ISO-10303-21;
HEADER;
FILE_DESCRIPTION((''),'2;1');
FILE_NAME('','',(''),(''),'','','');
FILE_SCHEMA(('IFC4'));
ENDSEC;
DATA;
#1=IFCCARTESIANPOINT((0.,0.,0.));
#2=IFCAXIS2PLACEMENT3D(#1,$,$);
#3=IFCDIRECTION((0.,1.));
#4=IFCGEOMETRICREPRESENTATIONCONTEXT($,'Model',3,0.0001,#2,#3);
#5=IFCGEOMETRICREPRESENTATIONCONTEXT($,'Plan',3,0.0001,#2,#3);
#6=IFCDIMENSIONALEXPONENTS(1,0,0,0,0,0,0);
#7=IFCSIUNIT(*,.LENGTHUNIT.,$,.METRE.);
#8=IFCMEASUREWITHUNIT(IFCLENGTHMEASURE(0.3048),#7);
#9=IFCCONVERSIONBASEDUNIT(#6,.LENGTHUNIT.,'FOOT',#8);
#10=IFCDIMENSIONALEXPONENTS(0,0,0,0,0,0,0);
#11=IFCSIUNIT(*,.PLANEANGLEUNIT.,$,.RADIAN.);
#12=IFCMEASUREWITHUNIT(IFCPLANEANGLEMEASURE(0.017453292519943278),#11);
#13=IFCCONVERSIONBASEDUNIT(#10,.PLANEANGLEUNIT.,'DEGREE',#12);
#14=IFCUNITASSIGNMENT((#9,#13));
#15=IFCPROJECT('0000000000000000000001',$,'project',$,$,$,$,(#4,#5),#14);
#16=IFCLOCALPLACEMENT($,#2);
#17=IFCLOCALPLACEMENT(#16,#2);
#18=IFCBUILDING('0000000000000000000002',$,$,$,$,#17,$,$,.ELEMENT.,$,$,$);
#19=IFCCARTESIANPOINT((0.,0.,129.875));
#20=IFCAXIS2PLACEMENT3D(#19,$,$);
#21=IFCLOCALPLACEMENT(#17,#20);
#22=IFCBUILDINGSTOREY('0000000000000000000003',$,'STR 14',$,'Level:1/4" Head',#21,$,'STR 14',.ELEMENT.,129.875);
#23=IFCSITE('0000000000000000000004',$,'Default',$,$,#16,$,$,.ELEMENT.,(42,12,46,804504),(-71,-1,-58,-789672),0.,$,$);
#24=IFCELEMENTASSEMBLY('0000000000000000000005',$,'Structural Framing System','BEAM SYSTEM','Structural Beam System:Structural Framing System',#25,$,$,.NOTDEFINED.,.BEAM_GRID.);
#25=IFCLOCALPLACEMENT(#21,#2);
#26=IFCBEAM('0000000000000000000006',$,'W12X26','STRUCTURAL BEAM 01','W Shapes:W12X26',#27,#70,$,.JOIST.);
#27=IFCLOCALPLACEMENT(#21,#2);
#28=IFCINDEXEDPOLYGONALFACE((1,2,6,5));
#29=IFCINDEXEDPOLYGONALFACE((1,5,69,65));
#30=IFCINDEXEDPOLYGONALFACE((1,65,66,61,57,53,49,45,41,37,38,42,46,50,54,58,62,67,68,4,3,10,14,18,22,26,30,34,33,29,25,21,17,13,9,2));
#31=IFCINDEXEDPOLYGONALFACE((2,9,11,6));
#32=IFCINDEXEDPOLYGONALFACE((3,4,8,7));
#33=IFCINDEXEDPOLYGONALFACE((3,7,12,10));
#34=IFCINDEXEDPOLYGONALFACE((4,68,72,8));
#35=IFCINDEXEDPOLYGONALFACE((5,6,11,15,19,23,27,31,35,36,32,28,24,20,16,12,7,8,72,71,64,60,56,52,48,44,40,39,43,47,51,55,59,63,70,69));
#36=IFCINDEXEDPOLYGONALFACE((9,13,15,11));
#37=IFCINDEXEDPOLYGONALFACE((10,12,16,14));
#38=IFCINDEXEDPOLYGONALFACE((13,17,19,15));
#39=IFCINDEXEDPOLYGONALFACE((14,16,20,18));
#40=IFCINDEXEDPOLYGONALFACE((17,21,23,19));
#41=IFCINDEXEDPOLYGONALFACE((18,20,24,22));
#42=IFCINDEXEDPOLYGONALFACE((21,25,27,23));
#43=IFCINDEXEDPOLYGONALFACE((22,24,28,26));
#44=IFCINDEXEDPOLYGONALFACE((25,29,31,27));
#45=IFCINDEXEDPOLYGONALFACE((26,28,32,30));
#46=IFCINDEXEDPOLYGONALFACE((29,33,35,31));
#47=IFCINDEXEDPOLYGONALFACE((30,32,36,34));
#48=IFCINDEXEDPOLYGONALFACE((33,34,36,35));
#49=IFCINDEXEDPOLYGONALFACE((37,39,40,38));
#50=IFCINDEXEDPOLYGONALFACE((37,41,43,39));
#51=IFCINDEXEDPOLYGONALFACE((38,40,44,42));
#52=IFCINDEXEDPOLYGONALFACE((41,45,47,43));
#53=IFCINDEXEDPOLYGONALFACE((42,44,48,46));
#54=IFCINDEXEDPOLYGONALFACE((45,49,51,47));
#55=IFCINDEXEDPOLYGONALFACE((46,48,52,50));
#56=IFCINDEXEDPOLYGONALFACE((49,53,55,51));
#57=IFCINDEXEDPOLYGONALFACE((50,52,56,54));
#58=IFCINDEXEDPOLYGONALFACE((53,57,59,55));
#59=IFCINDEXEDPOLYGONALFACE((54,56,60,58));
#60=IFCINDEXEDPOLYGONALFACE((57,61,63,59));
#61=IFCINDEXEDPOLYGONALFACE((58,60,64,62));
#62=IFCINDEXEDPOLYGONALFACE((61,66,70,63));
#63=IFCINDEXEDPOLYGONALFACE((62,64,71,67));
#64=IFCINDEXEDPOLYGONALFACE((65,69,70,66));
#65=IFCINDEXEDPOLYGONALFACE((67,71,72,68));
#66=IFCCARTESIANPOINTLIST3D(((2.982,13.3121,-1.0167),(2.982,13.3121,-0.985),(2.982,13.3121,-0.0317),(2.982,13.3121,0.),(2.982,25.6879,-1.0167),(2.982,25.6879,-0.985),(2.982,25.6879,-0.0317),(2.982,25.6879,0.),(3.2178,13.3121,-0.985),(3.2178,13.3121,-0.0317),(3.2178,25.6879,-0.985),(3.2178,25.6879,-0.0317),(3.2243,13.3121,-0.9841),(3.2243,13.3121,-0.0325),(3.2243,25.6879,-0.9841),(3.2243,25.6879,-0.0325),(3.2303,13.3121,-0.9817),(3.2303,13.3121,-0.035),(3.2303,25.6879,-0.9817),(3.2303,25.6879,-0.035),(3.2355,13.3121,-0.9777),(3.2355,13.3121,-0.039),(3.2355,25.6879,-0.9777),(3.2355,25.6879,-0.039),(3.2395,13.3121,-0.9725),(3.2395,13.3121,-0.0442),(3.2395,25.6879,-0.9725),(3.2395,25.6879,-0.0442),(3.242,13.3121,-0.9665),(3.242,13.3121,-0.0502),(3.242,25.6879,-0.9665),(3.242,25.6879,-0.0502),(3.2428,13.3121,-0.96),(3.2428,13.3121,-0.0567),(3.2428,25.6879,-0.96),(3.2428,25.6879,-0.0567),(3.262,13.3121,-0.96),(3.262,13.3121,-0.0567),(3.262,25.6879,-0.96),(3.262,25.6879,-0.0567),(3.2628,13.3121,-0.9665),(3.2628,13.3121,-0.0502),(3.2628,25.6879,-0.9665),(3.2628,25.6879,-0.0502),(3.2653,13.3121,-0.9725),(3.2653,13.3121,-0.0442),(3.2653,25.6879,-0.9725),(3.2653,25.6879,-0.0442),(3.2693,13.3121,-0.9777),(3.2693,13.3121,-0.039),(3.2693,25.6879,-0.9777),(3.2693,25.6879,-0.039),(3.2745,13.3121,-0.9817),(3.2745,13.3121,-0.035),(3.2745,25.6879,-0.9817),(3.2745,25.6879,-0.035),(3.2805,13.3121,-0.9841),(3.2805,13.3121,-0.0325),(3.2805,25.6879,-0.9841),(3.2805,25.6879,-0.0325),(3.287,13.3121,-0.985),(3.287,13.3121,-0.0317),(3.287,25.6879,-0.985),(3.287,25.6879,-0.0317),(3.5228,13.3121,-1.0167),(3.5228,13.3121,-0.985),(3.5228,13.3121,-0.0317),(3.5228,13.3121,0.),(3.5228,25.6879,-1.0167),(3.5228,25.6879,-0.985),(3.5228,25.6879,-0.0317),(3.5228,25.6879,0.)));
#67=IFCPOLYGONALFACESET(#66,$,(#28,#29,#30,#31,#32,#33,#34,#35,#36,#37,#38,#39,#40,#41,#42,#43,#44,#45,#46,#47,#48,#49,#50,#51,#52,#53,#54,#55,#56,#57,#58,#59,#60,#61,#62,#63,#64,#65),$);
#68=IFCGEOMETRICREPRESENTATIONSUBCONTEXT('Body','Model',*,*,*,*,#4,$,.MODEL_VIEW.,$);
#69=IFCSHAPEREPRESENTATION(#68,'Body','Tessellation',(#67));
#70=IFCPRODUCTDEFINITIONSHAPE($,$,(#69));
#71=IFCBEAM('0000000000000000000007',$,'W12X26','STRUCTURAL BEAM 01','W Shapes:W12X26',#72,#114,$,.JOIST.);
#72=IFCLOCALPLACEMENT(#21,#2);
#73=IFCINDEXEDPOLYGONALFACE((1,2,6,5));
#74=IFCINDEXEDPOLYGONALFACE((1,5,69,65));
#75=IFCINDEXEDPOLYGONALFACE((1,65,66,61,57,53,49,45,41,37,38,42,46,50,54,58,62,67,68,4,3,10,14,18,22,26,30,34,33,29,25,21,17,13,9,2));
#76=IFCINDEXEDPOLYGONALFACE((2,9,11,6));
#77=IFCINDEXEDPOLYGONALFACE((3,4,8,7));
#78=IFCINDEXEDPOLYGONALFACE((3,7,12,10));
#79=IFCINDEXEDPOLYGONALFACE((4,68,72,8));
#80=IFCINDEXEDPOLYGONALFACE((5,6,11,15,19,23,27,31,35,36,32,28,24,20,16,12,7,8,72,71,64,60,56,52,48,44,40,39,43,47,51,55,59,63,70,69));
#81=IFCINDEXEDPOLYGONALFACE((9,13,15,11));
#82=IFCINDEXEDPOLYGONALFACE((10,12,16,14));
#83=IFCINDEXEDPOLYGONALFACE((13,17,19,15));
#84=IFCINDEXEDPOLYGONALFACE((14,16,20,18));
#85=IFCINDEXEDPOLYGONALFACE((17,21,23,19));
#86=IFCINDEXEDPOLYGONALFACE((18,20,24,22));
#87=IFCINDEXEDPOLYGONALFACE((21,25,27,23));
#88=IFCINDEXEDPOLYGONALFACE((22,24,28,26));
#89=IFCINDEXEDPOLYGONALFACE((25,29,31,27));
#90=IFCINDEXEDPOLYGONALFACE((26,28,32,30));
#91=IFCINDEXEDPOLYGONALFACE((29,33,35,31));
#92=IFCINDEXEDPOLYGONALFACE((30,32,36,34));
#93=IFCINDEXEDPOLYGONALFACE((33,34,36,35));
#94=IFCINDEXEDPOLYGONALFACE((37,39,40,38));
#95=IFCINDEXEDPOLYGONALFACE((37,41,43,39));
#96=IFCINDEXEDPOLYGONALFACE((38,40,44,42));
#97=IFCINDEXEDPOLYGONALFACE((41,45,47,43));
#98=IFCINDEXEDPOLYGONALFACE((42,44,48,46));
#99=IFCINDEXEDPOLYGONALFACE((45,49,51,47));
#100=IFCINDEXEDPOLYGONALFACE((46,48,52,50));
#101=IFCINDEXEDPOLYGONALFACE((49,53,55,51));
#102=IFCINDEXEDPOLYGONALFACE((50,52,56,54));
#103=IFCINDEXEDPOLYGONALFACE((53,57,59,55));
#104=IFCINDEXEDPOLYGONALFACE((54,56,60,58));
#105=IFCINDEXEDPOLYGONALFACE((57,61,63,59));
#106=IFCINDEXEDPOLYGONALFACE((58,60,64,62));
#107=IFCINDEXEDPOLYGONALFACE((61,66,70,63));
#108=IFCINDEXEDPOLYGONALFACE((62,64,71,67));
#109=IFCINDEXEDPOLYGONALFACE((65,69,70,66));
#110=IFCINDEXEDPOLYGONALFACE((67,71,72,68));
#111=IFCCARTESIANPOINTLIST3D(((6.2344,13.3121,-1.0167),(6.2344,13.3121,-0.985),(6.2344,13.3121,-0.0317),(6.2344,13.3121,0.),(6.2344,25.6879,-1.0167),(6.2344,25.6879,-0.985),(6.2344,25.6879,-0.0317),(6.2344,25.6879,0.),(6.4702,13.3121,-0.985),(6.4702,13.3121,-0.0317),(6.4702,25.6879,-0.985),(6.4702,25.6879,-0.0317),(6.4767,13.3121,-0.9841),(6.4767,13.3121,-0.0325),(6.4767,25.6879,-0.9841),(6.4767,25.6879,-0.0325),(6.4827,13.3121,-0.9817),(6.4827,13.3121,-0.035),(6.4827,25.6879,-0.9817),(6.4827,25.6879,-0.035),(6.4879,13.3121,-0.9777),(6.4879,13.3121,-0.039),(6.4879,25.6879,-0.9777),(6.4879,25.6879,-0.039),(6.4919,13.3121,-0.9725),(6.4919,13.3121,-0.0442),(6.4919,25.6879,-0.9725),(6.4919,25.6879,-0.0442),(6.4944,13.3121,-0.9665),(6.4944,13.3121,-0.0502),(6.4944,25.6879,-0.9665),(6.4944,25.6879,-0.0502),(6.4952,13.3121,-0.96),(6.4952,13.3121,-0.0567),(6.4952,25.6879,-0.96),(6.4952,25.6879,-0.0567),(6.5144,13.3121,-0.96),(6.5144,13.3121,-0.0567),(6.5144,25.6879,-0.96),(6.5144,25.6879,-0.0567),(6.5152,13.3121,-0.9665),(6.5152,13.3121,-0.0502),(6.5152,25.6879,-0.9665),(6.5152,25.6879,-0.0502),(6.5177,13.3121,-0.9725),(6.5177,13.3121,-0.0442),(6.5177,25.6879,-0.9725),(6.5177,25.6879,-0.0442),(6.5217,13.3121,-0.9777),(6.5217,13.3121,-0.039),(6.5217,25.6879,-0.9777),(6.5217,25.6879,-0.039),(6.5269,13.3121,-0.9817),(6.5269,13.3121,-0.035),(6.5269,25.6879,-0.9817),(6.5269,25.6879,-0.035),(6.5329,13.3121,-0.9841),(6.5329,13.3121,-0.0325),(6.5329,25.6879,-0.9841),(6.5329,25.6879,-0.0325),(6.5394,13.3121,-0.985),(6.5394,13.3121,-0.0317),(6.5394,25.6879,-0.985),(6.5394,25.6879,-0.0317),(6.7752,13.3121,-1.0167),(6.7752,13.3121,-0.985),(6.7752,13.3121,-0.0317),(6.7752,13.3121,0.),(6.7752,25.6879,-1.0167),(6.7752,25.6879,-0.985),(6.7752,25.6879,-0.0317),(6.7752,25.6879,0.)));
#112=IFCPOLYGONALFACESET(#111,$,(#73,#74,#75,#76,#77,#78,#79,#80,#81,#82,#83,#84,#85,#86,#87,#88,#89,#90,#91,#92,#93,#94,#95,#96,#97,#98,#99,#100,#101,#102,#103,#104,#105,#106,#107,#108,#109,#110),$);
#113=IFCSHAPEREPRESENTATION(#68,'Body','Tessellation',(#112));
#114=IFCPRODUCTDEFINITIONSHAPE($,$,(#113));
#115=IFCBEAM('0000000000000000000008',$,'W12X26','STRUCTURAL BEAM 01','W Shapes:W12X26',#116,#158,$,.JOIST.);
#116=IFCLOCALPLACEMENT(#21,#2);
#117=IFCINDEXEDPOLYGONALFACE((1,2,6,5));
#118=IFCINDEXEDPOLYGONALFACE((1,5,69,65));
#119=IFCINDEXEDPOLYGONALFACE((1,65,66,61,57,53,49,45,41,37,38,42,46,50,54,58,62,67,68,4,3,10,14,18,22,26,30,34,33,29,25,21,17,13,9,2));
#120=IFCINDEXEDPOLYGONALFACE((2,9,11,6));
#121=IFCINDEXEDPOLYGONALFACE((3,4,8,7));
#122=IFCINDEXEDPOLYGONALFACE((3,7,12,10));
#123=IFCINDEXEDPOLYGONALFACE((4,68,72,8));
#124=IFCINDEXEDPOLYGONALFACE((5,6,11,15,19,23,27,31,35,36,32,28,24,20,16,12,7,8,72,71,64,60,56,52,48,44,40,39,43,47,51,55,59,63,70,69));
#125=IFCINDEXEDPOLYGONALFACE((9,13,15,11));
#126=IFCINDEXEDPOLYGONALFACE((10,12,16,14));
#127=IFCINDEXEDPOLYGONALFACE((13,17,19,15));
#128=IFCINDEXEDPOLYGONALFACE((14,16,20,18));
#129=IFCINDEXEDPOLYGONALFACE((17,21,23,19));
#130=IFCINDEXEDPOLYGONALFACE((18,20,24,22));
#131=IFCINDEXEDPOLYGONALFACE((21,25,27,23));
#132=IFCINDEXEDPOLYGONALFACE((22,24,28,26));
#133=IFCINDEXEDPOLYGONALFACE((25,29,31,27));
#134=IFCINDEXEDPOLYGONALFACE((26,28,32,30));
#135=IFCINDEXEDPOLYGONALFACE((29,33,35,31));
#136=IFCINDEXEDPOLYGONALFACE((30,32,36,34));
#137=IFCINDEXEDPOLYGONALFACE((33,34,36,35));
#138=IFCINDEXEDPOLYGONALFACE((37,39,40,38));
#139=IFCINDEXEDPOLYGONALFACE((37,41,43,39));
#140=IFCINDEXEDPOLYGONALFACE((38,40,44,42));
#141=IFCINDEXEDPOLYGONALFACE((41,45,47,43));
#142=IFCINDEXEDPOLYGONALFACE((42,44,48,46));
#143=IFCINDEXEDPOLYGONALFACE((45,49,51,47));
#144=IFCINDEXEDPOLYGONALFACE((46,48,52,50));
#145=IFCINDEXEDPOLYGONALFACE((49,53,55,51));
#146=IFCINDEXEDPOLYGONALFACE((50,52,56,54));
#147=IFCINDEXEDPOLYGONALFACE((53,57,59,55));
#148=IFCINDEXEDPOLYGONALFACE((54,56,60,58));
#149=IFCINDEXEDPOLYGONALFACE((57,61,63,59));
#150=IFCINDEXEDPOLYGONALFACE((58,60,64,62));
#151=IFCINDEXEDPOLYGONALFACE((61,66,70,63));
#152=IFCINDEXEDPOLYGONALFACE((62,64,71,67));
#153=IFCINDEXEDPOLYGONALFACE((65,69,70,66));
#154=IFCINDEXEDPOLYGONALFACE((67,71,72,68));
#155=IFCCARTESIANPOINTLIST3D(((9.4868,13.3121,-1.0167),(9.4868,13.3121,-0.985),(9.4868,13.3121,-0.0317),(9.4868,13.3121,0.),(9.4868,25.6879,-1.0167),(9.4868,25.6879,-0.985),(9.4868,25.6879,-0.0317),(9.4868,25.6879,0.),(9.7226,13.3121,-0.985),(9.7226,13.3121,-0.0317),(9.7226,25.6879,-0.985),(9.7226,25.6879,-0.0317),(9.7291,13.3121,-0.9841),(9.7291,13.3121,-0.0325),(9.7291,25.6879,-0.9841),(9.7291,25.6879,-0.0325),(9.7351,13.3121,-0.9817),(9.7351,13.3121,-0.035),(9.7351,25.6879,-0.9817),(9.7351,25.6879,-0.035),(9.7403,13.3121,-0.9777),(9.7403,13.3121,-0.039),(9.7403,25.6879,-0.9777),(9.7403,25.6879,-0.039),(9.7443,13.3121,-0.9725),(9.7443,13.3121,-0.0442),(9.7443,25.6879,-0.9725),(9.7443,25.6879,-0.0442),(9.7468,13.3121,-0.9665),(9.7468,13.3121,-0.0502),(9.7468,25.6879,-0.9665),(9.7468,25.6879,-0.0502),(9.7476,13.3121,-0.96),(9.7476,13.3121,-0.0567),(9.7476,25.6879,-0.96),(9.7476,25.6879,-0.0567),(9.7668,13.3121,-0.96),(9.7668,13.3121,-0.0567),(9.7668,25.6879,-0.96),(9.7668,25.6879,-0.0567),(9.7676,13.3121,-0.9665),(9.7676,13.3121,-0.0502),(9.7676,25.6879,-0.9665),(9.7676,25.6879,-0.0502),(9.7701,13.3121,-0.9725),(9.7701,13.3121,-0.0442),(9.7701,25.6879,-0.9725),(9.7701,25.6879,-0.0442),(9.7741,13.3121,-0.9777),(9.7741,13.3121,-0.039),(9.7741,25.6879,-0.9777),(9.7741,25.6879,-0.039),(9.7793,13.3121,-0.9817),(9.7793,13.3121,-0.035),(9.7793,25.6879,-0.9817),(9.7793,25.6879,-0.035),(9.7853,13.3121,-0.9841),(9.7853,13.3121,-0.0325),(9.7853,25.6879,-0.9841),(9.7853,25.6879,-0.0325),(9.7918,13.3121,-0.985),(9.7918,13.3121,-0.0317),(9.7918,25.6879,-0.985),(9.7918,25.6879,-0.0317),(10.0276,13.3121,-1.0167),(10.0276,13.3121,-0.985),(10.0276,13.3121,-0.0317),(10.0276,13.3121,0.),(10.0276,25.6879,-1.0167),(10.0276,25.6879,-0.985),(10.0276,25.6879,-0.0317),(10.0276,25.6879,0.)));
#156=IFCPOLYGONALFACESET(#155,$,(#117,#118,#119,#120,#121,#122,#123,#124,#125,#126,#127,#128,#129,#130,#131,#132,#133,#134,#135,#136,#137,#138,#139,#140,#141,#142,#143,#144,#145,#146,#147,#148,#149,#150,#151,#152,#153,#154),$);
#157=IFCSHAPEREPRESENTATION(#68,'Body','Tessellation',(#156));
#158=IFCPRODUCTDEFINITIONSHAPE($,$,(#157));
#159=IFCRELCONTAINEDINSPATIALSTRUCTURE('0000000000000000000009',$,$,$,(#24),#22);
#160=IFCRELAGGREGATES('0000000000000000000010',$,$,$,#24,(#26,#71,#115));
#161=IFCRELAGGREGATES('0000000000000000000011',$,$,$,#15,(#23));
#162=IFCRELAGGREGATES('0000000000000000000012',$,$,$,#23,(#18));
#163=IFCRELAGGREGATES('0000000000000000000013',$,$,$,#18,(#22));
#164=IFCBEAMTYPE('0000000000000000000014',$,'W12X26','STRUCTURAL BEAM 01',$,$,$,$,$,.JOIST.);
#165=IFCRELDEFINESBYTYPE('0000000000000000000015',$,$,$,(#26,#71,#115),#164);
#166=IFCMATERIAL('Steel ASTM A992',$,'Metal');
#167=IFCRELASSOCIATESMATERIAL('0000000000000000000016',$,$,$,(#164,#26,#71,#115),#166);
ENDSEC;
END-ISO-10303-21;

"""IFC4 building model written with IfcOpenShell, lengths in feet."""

from ifc_helpers import new_model, entity, si_unit, converted_unit, direction, frame, origin, place, context, subcontext, project, spatial, line, arc, indexed_curve, outline, extrude, source, transform, mapped, material, type_object, type_shapes, element, aggregate, save


model = new_model("IFC4")

# Units and contexts
model_context = context("Model", 3, precision=0.0001, world=origin(), true_north=direction((0.0, 1.0)))
plan_context = context("Plan", 3, precision=0.0001, world=origin(), true_north=direction((0.0, 1.0)))
body_context = subcontext(model_context, "Body", "Model", "MODEL_VIEW")
ifc_project = project(units=[converted_unit("LENGTHUNIT", "FOOT", entity("IfcLengthMeasure", 0.3048), si_unit("LENGTHUNIT", "METRE"), dimensions=[1, 0, 0, 0, 0, 0, 0]), converted_unit("PLANEANGLEUNIT", "DEGREE", entity("IfcPlaneAngleMeasure", 0.017453292519943278), si_unit("PLANEANGLEUNIT", "RADIAN"), dimensions=[0, 0, 0, 0, 0, 0, 0])], contexts=[model_context, plan_context])

# Site, building, storey
site_placement = place(None, origin())
site = spatial("IfcSite", under=ifc_project, at=site_placement, Name="Default", CompositionType="ELEMENT", RefLatitude=(42, 12, 46, 804504), RefLongitude=(-71, -1, -58, -789672), RefElevation=0.0)
building_placement = place(site_placement, origin())
building = spatial("IfcBuilding", under=site, at=building_placement, CompositionType="ELEMENT")
storey_placement = place(building_placement, frame((0.0, 0.0, 129.875)))
storey = spatial("IfcBuildingStorey", under=building, at=storey_placement, Name="STR 14", ObjectType="Level:1/4\" Head", LongName="STR 14", CompositionType="ELEMENT", Elevation=129.875)

# Shared definitions
ifc_material = material(Name="Steel ASTM A992", Category="Metal")

# Element assembly, beams
beam_type_1 = type_object("IfcBeamType", Name="W12X26", Description="STRUCTURAL BEAM 01", PredefinedType="JOIST", material=ifc_material)
shared_shape_1 = source(origin(), body_context, "Body", "SweptSolid", [
    extrude(outline(indexed_curve([(-0.2704, -0.4767), (-0.2704, -0.5083), (0.2704, -0.5083), (0.2704, -0.4767), (0.0346, -0.4767), (0.0169, -0.4693), (0.0096, -0.4517), (0.0096, 0.4517), (0.0169, 0.4693), (0.0346, 0.4767), (0.2704, 0.4767), (0.2704, 0.5083), (-0.2704, 0.5083), (-0.2704, 0.4767), (-0.0346, 0.4767), (-0.0169, 0.4693), (-0.0096, 0.4517), (-0.0096, -0.4517), (-0.0169, -0.4693), (-0.0346, -0.4767)], segments=[line(1, 2, 3, 4, 5), arc(5, 6, 7), line(7, 8), arc(8, 9, 10), line(10, 11, 12, 13, 14, 15), arc(15, 16, 17), line(17, 18), arc(18, 19, 20), line(20, 1)], self_intersect=False)), frame((-6.1879, 0.0, 0.0), z_axis=(-1.0, 0.0, 0.0), x_axis=(0.0, -1.0, 0.0)), (0.0, 0.0, -1.0), 12.3758),
])
type_shapes(beam_type_1, [shared_shape_1])
assembly_1_placement = place(storey_placement, origin())
assembly_1 = element("IfcElementAssembly", 1, at=assembly_1_placement, inside=storey, Name="Structural Framing System", Description="BEAM SYSTEM", ObjectType="Structural Beam System:Structural Framing System", AssemblyPlace="NOTDEFINED", PredefinedType="BEAM_GRID")
beam_1_placement = place(assembly_1_placement, frame((3.2524, 19.5, -0.5083), z_axis=(0.0, 0.0, 1.0), x_axis=(0.0, 1.0, 0.0)))
beam_1 = element("IfcBeam", 2, at=beam_1_placement, type_object=beam_type_1, material=ifc_material, Name="W12X26", Description="STRUCTURAL BEAM 01", ObjectType="W Shapes:W12X26", PredefinedType="JOIST", context=body_context, shape_type="MappedRepresentation", body=[
    mapped(shared_shape_1, transform((0.0, 0.0, 0.0), scale=1.0)),
])
beam_2_placement = place(assembly_1_placement, frame((6.5048, 19.5, -0.5083), z_axis=(0.0, 0.0, 1.0), x_axis=(0.0, 1.0, 0.0)))
beam_2 = element("IfcBeam", 3, at=beam_2_placement, type_object=beam_type_1, material=ifc_material, Name="W12X26", Description="STRUCTURAL BEAM 01", ObjectType="W Shapes:W12X26", PredefinedType="JOIST", context=body_context, shape_type="MappedRepresentation", body=[
    mapped(shared_shape_1, transform((0.0, 0.0, 0.0), scale=1.0)),
])
beam_3_placement = place(assembly_1_placement, frame((9.7572, 19.5, -0.5083), z_axis=(0.0, 0.0, 1.0), x_axis=(0.0, 1.0, 0.0)))
beam_3 = element("IfcBeam", 4, at=beam_3_placement, type_object=beam_type_1, material=ifc_material, Name="W12X26", Description="STRUCTURAL BEAM 01", ObjectType="W Shapes:W12X26", PredefinedType="JOIST", context=body_context, shape_type="MappedRepresentation", body=[
    mapped(shared_shape_1, transform((0.0, 0.0, 0.0), scale=1.0)),
])
aggregate(assembly_1, [beam_1, beam_2, beam_3])

save(model, "model.ifc")
